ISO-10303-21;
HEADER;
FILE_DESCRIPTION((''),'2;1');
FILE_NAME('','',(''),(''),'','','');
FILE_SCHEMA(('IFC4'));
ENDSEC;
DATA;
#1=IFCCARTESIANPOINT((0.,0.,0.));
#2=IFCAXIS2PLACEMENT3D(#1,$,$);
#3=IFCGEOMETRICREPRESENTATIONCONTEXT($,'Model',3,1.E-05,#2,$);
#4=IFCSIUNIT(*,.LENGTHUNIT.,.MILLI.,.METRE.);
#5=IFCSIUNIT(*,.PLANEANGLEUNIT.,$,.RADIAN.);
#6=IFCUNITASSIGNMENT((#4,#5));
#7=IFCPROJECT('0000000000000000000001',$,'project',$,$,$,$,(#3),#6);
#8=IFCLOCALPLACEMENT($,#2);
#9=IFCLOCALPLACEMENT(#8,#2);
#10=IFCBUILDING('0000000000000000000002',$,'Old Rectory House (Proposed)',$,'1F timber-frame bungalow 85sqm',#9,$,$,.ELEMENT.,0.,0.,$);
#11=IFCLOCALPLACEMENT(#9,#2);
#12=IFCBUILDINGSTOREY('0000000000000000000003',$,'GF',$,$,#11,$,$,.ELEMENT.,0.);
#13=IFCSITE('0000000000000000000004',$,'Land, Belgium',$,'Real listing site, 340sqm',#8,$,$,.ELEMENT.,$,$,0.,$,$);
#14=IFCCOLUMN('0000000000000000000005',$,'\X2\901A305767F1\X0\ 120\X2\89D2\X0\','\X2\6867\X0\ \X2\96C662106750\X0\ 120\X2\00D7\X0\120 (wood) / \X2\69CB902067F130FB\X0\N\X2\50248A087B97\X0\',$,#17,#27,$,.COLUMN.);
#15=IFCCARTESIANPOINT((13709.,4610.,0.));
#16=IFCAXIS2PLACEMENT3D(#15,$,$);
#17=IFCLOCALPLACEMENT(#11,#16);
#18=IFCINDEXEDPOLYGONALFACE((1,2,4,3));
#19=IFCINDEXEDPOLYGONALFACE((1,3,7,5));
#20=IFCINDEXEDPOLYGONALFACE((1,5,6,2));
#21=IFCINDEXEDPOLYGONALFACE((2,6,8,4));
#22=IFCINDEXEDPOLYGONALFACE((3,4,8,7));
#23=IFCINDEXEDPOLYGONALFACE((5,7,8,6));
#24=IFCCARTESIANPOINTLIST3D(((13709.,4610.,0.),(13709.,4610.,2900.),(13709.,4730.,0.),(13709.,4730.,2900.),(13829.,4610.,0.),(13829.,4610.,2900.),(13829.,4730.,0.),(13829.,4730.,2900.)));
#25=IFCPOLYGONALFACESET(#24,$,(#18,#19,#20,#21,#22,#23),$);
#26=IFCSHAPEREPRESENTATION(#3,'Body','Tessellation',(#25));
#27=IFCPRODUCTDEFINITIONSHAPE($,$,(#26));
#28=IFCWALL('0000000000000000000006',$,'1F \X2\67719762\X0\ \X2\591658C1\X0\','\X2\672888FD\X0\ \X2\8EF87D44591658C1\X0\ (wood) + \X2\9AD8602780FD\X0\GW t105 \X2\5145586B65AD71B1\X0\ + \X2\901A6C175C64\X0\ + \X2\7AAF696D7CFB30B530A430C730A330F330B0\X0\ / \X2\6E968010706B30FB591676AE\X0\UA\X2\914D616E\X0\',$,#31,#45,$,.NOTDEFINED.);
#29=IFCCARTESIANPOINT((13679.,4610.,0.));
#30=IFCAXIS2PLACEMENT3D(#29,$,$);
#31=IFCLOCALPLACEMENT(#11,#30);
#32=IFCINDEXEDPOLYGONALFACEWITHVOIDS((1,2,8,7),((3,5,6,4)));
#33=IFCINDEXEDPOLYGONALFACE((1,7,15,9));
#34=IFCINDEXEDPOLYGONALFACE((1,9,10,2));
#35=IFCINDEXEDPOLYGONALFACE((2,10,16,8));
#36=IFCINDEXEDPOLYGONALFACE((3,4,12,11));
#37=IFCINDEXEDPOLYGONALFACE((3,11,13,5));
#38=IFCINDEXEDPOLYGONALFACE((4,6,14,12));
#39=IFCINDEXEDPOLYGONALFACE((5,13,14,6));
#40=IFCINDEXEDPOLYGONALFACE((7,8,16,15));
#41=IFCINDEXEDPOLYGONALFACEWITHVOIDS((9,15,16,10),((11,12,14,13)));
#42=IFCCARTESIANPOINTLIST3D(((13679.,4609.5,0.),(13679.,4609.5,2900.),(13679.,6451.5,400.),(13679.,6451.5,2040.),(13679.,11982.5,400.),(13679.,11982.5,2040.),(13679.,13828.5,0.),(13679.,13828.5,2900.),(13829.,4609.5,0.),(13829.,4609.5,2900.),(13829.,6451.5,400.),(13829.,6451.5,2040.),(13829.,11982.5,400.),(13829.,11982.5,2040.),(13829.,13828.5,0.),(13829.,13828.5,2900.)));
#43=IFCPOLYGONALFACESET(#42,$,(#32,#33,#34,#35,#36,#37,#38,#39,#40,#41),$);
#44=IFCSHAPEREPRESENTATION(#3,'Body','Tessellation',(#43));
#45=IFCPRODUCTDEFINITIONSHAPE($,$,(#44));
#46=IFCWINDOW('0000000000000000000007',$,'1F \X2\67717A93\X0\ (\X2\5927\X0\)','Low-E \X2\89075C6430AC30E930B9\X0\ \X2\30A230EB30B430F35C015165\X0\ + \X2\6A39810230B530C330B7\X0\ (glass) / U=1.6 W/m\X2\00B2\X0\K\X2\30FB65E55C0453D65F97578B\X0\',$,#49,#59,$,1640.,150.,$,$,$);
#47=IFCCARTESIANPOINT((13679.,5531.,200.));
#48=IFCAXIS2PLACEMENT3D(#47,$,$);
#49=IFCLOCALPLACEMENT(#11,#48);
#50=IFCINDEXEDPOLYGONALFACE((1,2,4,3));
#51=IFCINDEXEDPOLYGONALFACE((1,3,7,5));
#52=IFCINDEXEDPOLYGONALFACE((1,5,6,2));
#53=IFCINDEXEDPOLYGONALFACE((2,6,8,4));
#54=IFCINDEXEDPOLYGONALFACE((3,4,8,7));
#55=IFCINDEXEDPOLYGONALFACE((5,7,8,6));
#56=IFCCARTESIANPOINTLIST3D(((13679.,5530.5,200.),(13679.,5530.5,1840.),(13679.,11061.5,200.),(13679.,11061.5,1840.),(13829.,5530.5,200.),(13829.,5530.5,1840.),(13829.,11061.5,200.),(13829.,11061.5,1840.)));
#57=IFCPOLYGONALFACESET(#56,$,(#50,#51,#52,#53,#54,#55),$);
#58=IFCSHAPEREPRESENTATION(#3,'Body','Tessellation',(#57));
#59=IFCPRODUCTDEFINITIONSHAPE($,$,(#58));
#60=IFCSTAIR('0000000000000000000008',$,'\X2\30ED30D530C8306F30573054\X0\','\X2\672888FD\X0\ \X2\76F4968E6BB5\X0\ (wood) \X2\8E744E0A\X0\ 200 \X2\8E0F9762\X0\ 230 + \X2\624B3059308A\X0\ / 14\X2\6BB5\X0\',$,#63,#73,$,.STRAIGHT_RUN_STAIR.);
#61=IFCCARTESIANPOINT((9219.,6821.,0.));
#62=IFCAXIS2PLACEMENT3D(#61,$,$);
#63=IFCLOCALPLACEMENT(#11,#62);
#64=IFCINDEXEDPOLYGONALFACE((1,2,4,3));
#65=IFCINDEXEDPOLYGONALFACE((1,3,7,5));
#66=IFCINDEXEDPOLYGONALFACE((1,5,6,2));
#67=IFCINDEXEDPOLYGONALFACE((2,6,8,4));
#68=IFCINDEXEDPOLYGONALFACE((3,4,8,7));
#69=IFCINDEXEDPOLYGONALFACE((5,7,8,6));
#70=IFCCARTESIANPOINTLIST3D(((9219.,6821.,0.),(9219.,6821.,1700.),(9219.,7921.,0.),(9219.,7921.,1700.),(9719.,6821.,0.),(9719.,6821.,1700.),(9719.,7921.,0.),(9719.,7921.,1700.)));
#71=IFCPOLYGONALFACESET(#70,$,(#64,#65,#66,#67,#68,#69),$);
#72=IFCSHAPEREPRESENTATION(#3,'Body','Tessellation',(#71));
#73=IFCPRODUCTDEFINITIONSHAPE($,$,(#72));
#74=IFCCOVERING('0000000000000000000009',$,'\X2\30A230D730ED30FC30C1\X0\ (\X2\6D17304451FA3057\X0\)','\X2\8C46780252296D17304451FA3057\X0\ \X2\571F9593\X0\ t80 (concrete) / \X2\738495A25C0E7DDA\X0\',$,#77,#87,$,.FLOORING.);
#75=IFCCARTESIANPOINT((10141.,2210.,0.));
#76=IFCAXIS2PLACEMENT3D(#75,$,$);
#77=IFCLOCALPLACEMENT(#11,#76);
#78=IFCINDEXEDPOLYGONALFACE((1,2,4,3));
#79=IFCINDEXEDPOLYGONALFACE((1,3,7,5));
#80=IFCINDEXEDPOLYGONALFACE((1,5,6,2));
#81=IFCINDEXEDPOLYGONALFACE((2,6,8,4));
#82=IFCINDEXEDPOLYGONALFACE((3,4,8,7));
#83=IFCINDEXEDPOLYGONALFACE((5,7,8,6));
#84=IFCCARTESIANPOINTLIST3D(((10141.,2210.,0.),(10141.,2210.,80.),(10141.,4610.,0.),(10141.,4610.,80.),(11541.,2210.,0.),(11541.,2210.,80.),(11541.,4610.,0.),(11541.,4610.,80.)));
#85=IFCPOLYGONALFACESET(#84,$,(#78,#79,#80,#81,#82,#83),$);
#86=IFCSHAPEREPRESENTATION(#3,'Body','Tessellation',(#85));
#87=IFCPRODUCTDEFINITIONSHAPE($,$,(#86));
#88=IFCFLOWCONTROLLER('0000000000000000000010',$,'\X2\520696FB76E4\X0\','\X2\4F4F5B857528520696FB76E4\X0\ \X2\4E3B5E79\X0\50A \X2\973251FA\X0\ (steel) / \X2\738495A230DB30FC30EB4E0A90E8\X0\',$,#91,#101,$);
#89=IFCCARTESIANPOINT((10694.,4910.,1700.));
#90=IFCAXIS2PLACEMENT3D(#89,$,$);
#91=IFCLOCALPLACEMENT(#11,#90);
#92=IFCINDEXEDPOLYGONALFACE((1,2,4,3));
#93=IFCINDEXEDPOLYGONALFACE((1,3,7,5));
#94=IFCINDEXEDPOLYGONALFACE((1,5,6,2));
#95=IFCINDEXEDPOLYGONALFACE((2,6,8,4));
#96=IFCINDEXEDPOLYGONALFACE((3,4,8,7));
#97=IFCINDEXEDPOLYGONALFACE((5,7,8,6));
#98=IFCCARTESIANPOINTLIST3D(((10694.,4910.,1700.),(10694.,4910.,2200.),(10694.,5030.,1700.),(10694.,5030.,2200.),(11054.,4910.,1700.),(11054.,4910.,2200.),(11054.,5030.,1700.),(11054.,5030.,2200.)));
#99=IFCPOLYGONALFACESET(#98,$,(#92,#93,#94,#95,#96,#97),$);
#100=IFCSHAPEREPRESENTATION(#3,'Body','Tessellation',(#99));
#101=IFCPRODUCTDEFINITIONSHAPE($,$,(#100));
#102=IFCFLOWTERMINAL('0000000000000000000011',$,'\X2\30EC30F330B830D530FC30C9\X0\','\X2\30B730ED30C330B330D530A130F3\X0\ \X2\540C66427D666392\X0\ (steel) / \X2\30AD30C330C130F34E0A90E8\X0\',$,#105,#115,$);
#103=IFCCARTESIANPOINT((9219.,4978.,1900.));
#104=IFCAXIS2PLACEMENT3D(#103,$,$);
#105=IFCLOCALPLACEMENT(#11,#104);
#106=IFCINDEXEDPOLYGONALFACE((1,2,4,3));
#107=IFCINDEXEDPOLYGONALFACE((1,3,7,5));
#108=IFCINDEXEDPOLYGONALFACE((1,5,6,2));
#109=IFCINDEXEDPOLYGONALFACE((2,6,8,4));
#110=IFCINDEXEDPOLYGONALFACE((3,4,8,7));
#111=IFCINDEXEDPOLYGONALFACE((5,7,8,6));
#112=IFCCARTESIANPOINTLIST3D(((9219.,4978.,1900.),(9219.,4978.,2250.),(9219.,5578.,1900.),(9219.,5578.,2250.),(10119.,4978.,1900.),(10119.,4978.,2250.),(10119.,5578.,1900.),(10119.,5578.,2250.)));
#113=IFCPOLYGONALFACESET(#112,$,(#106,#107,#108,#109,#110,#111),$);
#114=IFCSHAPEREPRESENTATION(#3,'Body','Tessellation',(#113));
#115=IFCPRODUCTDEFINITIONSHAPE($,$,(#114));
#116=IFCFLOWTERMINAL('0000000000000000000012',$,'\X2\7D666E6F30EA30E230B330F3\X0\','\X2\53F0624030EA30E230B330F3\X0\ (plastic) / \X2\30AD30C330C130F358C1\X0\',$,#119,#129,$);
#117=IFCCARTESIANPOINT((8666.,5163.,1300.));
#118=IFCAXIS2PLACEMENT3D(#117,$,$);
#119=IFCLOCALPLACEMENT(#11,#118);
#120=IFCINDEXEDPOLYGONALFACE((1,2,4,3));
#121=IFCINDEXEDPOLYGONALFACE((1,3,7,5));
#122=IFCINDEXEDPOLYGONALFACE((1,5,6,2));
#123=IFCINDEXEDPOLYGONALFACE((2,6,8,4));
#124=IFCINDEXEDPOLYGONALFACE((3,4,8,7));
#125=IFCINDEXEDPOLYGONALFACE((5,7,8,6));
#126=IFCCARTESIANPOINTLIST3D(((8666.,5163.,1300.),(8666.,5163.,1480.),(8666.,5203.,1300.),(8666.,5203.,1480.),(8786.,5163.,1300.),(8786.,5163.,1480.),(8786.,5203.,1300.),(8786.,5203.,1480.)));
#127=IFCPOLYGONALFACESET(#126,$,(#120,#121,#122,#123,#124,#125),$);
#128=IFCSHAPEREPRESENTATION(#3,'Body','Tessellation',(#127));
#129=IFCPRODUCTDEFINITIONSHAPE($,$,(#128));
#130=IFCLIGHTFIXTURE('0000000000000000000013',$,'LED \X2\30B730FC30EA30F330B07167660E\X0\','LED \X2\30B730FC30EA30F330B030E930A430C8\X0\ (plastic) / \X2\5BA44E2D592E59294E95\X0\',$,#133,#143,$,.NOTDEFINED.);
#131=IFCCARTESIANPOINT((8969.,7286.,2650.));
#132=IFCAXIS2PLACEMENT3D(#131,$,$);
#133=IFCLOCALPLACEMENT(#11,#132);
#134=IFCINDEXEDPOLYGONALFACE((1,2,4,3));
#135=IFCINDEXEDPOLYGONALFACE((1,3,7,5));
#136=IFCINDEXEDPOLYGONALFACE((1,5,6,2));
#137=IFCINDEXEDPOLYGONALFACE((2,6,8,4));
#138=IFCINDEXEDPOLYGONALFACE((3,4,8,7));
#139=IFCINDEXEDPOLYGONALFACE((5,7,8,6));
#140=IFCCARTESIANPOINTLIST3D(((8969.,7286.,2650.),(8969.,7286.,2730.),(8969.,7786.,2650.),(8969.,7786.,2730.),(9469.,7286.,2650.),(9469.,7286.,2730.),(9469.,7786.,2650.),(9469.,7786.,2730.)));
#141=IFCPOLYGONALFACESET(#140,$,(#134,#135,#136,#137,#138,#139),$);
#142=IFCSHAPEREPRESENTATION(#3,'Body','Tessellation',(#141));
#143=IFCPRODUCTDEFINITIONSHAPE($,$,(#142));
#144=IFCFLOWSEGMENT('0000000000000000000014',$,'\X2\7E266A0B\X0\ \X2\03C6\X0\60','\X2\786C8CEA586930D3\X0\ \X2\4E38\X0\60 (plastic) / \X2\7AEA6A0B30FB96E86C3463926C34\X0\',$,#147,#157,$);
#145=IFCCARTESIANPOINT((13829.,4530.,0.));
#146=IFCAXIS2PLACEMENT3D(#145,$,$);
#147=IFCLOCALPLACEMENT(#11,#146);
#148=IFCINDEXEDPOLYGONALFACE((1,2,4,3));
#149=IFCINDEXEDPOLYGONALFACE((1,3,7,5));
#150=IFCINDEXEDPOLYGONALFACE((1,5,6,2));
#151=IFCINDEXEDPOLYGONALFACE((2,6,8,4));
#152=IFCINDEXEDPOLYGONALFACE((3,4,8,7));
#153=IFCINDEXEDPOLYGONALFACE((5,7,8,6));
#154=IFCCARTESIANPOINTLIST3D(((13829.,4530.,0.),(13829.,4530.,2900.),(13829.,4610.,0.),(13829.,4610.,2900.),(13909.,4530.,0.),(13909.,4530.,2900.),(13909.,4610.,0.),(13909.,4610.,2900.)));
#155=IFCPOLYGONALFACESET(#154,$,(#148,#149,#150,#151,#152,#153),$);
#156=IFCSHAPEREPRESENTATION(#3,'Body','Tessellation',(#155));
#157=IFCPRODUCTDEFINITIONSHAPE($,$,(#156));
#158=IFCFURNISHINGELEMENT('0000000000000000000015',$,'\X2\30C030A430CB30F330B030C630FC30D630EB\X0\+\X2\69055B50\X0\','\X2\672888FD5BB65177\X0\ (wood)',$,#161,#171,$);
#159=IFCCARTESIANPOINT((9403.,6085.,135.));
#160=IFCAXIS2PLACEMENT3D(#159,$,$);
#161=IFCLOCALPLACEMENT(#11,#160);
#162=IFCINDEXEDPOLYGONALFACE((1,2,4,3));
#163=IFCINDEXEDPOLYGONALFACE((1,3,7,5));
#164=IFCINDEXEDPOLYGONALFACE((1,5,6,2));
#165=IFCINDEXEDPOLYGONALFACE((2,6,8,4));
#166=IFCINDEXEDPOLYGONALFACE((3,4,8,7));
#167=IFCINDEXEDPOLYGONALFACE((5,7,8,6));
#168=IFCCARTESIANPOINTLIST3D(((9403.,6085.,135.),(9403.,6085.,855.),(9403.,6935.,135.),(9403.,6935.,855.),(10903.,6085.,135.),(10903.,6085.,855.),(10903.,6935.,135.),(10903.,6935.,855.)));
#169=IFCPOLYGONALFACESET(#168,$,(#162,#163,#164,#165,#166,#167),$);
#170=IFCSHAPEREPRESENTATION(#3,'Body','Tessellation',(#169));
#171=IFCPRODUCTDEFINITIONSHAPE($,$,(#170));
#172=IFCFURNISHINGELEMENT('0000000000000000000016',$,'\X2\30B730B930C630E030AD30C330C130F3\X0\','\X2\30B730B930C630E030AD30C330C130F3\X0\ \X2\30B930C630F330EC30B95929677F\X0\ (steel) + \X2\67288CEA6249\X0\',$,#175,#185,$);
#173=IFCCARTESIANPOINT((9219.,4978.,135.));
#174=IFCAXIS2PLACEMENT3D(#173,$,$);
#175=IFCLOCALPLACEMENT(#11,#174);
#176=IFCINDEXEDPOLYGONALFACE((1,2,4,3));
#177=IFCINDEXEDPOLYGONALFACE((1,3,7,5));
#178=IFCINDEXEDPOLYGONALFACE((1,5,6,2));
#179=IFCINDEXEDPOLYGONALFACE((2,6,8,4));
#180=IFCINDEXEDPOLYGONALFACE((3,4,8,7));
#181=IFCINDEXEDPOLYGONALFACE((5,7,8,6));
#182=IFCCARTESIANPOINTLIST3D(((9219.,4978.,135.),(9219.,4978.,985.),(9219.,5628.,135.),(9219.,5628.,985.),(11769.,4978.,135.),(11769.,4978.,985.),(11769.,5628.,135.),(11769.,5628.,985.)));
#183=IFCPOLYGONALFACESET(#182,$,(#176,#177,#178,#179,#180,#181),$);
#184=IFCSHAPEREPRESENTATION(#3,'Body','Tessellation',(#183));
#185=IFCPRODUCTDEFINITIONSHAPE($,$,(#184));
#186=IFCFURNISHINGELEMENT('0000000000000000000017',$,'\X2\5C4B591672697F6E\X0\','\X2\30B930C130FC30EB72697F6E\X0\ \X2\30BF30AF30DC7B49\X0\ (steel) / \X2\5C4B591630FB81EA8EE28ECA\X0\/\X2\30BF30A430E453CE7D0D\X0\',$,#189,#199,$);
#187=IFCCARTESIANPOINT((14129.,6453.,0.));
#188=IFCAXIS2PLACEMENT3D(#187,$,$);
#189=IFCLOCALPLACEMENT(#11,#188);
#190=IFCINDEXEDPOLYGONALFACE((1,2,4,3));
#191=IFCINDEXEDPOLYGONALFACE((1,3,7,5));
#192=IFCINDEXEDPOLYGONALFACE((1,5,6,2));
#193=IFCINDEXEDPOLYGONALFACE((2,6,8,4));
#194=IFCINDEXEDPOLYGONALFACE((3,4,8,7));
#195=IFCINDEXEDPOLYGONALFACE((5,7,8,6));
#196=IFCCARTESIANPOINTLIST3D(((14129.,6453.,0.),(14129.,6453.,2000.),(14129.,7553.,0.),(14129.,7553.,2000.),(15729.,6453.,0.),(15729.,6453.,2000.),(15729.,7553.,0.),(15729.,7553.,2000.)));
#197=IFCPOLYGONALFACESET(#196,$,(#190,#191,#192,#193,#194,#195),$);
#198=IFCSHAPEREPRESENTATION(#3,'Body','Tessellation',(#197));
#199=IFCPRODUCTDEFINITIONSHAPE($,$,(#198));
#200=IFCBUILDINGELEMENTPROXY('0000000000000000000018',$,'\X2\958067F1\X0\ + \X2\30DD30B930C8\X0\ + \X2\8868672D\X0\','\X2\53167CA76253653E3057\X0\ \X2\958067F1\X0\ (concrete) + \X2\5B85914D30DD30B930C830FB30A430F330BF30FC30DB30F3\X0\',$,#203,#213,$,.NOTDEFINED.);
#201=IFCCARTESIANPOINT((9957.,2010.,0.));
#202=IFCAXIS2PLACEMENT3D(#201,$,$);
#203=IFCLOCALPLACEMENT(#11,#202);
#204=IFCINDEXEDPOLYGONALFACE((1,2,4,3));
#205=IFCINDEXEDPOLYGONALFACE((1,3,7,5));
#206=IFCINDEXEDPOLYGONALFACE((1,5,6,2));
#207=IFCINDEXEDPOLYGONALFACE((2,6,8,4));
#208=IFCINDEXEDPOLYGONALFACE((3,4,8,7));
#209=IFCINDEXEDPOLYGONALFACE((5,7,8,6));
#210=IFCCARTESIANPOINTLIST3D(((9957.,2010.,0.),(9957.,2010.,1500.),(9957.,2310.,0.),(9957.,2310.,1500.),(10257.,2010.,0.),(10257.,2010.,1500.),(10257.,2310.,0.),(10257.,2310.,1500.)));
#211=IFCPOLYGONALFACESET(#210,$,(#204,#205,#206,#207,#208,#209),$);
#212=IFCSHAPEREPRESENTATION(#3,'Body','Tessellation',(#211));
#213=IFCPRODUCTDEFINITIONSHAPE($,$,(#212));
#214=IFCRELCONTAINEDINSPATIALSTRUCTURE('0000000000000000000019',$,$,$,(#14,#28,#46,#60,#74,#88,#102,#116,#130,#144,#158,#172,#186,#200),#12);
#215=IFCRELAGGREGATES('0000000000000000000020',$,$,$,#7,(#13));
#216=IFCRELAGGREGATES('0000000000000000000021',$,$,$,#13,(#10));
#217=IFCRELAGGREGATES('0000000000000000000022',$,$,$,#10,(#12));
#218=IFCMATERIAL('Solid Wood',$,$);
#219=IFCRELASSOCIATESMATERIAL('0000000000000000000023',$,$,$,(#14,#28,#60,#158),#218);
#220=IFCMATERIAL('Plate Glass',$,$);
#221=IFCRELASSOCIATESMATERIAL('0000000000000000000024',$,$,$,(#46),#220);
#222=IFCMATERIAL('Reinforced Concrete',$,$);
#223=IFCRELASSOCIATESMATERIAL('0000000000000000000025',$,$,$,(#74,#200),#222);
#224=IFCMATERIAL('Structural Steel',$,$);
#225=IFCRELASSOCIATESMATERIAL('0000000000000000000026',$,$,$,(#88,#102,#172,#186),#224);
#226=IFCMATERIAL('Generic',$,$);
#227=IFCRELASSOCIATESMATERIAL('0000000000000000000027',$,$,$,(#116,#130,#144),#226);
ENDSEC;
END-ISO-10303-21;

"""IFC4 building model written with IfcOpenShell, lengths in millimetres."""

from ifc_helpers import new_model, si_unit, frame, frame_2d, origin, place, context, project, spatial, rectangle, extrude, material, element, fill, save


model = new_model("IFC4")

# Units and contexts
model_context = context("Model", 3, precision=1e-05, world=origin())
ifc_project = project(units=[si_unit("LENGTHUNIT", "METRE", prefix="MILLI"), si_unit("PLANEANGLEUNIT", "RADIAN")], contexts=[model_context])

# Site, building, storey
site_placement = place(None, origin())
site = spatial("IfcSite", under=ifc_project, at=site_placement, Name="Land, Belgium", ObjectType="Real listing site, 340sqm", CompositionType="ELEMENT", RefElevation=0.0)
building_placement = place(site_placement, origin())
building = spatial("IfcBuilding", under=site, at=building_placement, Name="Old Rectory House (Proposed)", ObjectType="1F timber-frame bungalow 85sqm", CompositionType="ELEMENT", ElevationOfRefHeight=0.0, ElevationOfTerrain=0.0)
storey_placement = place(building_placement, origin())
storey = spatial("IfcBuildingStorey", under=building, at=storey_placement, Name="GF", CompositionType="ELEMENT", Elevation=0.0)

# Column
ifc_material_1 = material(Name="Solid Wood")
column_1_placement = place(storey_placement, frame((13709.0, 4610.0, 0.0)))
element("IfcColumn", 1, at=column_1_placement, inside=storey, material=ifc_material_1, Name="通し柱 120角", Description="桧 集成材 120×120 (wood) / 構造柱・N値計算", PredefinedType="COLUMN", context=model_context, shape_type="SweptSolid", body=[
    extrude(rectangle(XDim=120.0, YDim=120.0, at=frame_2d((60.0, 60.0))), frame((13709.0, 4610.0, 0.0)), (0.0, 0.0, 1.0), 2900.0),
])

# Wall, opening, window
wall_1_placement = place(storey_placement, frame((13679.0, 4610.0, 0.0)))
wall_1 = element("IfcWall", 2, at=wall_1_placement, inside=storey, material=ifc_material_1, Name="1F 東面 外壁", Description="木製 軸組外壁 (wood) + 高性能GW t105 充填断熱 + 通気層 + 窯業系サイディング / 準耐火・外皮UA配慮", PredefinedType="NOTDEFINED", context=model_context, shape_type="SweptSolid", body=[
    extrude(rectangle(XDim=150.0, YDim=9219.0, at=frame_2d((75.0, 4609.0))), frame((13679.0, 4610.0, 0.0)), (0.0, 0.0, 1.0), 2900.0),
])
opening_placement = place(storey_placement, frame((13679.0, 5531.0, 200.0)))
opening = element("IfcOpeningElement", 3, at=opening_placement, cuts=wall_1, PredefinedType="NOTDEFINED", context=model_context, shape_type="SweptSolid", body=[
    extrude(rectangle(XDim=150.0, YDim=5531.0, at=frame_2d((75.0, 2765.0))), frame((13679.0, 5531.0, 200.0)), (0.0, 0.0, 1.0), 1640.0),
])
ifc_material_2 = material(Name="Plate Glass")
window_placement = place(storey_placement, frame((13679.0, 5531.0, 200.0)))
window = element("IfcWindow", 4, at=window_placement, inside=storey, material=ifc_material_2, Name="1F 東窓 (大)", Description="Low-E 複層ガラス アルゴン封入 + 樹脂サッシ (glass) / U=1.6 W/m²K・日射取得型", OverallHeight=1640.0, OverallWidth=150.0, context=model_context, shape_type="SweptSolid", body=[
    extrude(rectangle(XDim=150.0, YDim=5531.0, at=frame_2d((75.0, 2765.0))), frame((13679.0, 5531.0, 200.0)), (0.0, 0.0, 1.0), 1640.0),
])
fill(opening, window)

# Stair
stair_placement = place(storey_placement, frame((9219.0, 6821.0, 0.0)))
element("IfcStair", 5, at=stair_placement, inside=storey, material=ifc_material_1, Name="ロフトはしご", Description="木製 直階段 (wood) 蹴上 200 踏面 230 + 手すり / 14段", PredefinedType="STRAIGHT_RUN_STAIR", context=model_context, shape_type="SweptSolid", body=[
    extrude(rectangle(XDim=500.0, YDim=1100.0, at=frame_2d((250.0, 550.0))), frame((9219.0, 6821.0, 0.0)), (0.0, 0.0, 1.0), 1700.0),
])

# Covering
ifc_material_3 = material(Name="Reinforced Concrete")
covering_placement = place(storey_placement, frame((10141.0, 2210.0, 0.0)))
element("IfcCovering", 6, at=covering_placement, inside=storey, material=ifc_material_3, Name="アプローチ (洗い出し)", Description="豆砂利洗い出し 土間 t80 (concrete) / 玄関導線", PredefinedType="FLOORING", context=model_context, shape_type="SweptSolid", body=[
    extrude(rectangle(XDim=1400.0, YDim=2400.0, at=frame_2d((700.0, 1200.0))), frame((10141.0, 2210.0, 0.0)), (0.0, 0.0, 1.0), 80.0),
])

# Flow controller
ifc_material_4 = material(Name="Structural Steel")
flow_controller_placement = place(storey_placement, frame((10694.0, 4910.0, 1700.0)))
element("IfcFlowController", 7, at=flow_controller_placement, inside=storey, material=ifc_material_4, Name="分電盤", Description="住宅用分電盤 主幹50A 露出 (steel) / 玄関ホール上部", context=model_context, shape_type="SweptSolid", body=[
    extrude(rectangle(XDim=360.0, YDim=120.0, at=frame_2d((180.0, 60.0))), frame((10694.0, 4910.0, 1700.0)), (0.0, 0.0, 1.0), 500.0),
])

# Flow terminals
flow_terminal_1_placement = place(storey_placement, frame((9219.0, 4978.0, 1900.0)))
element("IfcFlowTerminal", 8, at=flow_terminal_1_placement, inside=storey, material=ifc_material_4, Name="レンジフード", Description="シロッコファン 同時給排 (steel) / キッチン上部", context=model_context, shape_type="SweptSolid", body=[
    extrude(rectangle(XDim=900.0, YDim=600.0, at=frame_2d((450.0, 300.0))), frame((9219.0, 4978.0, 1900.0)), (0.0, 0.0, 1.0), 350.0),
])
ifc_material_5 = material(Name="Generic")
flow_terminal_2_placement = place(storey_placement, frame((8666.0, 5163.0, 1300.0)))
element("IfcFlowTerminal", 9, at=flow_terminal_2_placement, inside=storey, material=ifc_material_5, Name="給湯リモコン", Description="台所リモコン (plastic) / キッチン壁", context=model_context, shape_type="SweptSolid", body=[
    extrude(rectangle(XDim=120.0, YDim=40.0, at=frame_2d((60.0, 20.0))), frame((8666.0, 5163.0, 1300.0)), (0.0, 0.0, 1.0), 180.0),
])

# Light fixture
light_fixture_placement = place(storey_placement, frame((8969.0, 7286.0, 2650.0)))
element("IfcLightFixture", 10, at=light_fixture_placement, inside=storey, material=ifc_material_5, Name="LED シーリング照明", Description="LED シーリングライト (plastic) / 室中央天井", PredefinedType="NOTDEFINED", context=model_context, shape_type="SweptSolid", body=[
    extrude(rectangle(XDim=500.0, YDim=500.0, at=frame_2d((250.0, 250.0))), frame((8969.0, 7286.0, 2650.0)), (0.0, 0.0, 1.0), 80.0),
])

# Flow segment
flow_segment_placement = place(storey_placement, frame((13829.0, 4530.0, 0.0)))
element("IfcFlowSegment", 11, at=flow_segment_placement, inside=storey, material=ifc_material_5, Name="縦樋 φ60", Description="硬質塩ビ 丸60 (plastic) / 竪樋・雨水排水", context=model_context, shape_type="SweptSolid", body=[
    extrude(rectangle(XDim=80.0, YDim=80.0, at=frame_2d((40.0, 40.0))), frame((13829.0, 4530.0, 0.0)), (0.0, 0.0, 1.0), 2900.0),
])

# Furnishing elements
furnishing_1_placement = place(storey_placement, frame((9403.0, 6085.0, 135.0)))
element("IfcFurnishingElement", 12, at=furnishing_1_placement, inside=storey, material=ifc_material_1, Name="ダイニングテーブル+椅子", Description="木製家具 (wood)", context=model_context, shape_type="SweptSolid", body=[
    extrude(rectangle(XDim=1500.0, YDim=850.0, at=frame_2d((750.0, 425.0))), frame((9403.0, 6085.0, 135.0)), (0.0, 0.0, 1.0), 720.0),
])
furnishing_2_placement = place(storey_placement, frame((9219.0, 4978.0, 135.0)))
element("IfcFurnishingElement", 13, at=furnishing_2_placement, inside=storey, material=ifc_material_4, Name="システムキッチン", Description="システムキッチン ステンレス天板 (steel) + 木質扉", context=model_context, shape_type="SweptSolid", body=[
    extrude(rectangle(XDim=2550.0, YDim=650.0, at=frame_2d((1275.0, 325.0))), frame((9219.0, 4978.0, 135.0)), (0.0, 0.0, 1.0), 850.0),
])
furnishing_3_placement = place(storey_placement, frame((14129.0, 6453.0, 0.0)))
element("IfcFurnishingElement", 14, at=furnishing_3_placement, inside=storey, material=ifc_material_4, Name="屋外物置", Description="スチール物置 タクボ等 (steel) / 屋外・自転車/タイヤ収納", context=model_context, shape_type="SweptSolid", body=[
    extrude(rectangle(XDim=1600.0, YDim=1100.0, at=frame_2d((800.0, 550.0))), frame((14129.0, 6453.0, 0.0)), (0.0, 0.0, 1.0), 2000.0),
])

# Building element proxy
proxy_placement = place(storey_placement, frame((9957.0, 2010.0, 0.0)))
element("IfcBuildingElementProxy", 15, at=proxy_placement, inside=storey, material=ifc_material_3, Name="門柱 + ポスト + 表札", Description="化粧打放し 門柱 (concrete) + 宅配ポスト・インターホン", PredefinedType="NOTDEFINED", context=model_context, shape_type="SweptSolid", body=[
    extrude(rectangle(XDim=300.0, YDim=300.0, at=frame_2d((150.0, 150.0))), frame((9957.0, 2010.0, 0.0)), (0.0, 0.0, 1.0), 1500.0),
])

save(model, "model.ifc")
